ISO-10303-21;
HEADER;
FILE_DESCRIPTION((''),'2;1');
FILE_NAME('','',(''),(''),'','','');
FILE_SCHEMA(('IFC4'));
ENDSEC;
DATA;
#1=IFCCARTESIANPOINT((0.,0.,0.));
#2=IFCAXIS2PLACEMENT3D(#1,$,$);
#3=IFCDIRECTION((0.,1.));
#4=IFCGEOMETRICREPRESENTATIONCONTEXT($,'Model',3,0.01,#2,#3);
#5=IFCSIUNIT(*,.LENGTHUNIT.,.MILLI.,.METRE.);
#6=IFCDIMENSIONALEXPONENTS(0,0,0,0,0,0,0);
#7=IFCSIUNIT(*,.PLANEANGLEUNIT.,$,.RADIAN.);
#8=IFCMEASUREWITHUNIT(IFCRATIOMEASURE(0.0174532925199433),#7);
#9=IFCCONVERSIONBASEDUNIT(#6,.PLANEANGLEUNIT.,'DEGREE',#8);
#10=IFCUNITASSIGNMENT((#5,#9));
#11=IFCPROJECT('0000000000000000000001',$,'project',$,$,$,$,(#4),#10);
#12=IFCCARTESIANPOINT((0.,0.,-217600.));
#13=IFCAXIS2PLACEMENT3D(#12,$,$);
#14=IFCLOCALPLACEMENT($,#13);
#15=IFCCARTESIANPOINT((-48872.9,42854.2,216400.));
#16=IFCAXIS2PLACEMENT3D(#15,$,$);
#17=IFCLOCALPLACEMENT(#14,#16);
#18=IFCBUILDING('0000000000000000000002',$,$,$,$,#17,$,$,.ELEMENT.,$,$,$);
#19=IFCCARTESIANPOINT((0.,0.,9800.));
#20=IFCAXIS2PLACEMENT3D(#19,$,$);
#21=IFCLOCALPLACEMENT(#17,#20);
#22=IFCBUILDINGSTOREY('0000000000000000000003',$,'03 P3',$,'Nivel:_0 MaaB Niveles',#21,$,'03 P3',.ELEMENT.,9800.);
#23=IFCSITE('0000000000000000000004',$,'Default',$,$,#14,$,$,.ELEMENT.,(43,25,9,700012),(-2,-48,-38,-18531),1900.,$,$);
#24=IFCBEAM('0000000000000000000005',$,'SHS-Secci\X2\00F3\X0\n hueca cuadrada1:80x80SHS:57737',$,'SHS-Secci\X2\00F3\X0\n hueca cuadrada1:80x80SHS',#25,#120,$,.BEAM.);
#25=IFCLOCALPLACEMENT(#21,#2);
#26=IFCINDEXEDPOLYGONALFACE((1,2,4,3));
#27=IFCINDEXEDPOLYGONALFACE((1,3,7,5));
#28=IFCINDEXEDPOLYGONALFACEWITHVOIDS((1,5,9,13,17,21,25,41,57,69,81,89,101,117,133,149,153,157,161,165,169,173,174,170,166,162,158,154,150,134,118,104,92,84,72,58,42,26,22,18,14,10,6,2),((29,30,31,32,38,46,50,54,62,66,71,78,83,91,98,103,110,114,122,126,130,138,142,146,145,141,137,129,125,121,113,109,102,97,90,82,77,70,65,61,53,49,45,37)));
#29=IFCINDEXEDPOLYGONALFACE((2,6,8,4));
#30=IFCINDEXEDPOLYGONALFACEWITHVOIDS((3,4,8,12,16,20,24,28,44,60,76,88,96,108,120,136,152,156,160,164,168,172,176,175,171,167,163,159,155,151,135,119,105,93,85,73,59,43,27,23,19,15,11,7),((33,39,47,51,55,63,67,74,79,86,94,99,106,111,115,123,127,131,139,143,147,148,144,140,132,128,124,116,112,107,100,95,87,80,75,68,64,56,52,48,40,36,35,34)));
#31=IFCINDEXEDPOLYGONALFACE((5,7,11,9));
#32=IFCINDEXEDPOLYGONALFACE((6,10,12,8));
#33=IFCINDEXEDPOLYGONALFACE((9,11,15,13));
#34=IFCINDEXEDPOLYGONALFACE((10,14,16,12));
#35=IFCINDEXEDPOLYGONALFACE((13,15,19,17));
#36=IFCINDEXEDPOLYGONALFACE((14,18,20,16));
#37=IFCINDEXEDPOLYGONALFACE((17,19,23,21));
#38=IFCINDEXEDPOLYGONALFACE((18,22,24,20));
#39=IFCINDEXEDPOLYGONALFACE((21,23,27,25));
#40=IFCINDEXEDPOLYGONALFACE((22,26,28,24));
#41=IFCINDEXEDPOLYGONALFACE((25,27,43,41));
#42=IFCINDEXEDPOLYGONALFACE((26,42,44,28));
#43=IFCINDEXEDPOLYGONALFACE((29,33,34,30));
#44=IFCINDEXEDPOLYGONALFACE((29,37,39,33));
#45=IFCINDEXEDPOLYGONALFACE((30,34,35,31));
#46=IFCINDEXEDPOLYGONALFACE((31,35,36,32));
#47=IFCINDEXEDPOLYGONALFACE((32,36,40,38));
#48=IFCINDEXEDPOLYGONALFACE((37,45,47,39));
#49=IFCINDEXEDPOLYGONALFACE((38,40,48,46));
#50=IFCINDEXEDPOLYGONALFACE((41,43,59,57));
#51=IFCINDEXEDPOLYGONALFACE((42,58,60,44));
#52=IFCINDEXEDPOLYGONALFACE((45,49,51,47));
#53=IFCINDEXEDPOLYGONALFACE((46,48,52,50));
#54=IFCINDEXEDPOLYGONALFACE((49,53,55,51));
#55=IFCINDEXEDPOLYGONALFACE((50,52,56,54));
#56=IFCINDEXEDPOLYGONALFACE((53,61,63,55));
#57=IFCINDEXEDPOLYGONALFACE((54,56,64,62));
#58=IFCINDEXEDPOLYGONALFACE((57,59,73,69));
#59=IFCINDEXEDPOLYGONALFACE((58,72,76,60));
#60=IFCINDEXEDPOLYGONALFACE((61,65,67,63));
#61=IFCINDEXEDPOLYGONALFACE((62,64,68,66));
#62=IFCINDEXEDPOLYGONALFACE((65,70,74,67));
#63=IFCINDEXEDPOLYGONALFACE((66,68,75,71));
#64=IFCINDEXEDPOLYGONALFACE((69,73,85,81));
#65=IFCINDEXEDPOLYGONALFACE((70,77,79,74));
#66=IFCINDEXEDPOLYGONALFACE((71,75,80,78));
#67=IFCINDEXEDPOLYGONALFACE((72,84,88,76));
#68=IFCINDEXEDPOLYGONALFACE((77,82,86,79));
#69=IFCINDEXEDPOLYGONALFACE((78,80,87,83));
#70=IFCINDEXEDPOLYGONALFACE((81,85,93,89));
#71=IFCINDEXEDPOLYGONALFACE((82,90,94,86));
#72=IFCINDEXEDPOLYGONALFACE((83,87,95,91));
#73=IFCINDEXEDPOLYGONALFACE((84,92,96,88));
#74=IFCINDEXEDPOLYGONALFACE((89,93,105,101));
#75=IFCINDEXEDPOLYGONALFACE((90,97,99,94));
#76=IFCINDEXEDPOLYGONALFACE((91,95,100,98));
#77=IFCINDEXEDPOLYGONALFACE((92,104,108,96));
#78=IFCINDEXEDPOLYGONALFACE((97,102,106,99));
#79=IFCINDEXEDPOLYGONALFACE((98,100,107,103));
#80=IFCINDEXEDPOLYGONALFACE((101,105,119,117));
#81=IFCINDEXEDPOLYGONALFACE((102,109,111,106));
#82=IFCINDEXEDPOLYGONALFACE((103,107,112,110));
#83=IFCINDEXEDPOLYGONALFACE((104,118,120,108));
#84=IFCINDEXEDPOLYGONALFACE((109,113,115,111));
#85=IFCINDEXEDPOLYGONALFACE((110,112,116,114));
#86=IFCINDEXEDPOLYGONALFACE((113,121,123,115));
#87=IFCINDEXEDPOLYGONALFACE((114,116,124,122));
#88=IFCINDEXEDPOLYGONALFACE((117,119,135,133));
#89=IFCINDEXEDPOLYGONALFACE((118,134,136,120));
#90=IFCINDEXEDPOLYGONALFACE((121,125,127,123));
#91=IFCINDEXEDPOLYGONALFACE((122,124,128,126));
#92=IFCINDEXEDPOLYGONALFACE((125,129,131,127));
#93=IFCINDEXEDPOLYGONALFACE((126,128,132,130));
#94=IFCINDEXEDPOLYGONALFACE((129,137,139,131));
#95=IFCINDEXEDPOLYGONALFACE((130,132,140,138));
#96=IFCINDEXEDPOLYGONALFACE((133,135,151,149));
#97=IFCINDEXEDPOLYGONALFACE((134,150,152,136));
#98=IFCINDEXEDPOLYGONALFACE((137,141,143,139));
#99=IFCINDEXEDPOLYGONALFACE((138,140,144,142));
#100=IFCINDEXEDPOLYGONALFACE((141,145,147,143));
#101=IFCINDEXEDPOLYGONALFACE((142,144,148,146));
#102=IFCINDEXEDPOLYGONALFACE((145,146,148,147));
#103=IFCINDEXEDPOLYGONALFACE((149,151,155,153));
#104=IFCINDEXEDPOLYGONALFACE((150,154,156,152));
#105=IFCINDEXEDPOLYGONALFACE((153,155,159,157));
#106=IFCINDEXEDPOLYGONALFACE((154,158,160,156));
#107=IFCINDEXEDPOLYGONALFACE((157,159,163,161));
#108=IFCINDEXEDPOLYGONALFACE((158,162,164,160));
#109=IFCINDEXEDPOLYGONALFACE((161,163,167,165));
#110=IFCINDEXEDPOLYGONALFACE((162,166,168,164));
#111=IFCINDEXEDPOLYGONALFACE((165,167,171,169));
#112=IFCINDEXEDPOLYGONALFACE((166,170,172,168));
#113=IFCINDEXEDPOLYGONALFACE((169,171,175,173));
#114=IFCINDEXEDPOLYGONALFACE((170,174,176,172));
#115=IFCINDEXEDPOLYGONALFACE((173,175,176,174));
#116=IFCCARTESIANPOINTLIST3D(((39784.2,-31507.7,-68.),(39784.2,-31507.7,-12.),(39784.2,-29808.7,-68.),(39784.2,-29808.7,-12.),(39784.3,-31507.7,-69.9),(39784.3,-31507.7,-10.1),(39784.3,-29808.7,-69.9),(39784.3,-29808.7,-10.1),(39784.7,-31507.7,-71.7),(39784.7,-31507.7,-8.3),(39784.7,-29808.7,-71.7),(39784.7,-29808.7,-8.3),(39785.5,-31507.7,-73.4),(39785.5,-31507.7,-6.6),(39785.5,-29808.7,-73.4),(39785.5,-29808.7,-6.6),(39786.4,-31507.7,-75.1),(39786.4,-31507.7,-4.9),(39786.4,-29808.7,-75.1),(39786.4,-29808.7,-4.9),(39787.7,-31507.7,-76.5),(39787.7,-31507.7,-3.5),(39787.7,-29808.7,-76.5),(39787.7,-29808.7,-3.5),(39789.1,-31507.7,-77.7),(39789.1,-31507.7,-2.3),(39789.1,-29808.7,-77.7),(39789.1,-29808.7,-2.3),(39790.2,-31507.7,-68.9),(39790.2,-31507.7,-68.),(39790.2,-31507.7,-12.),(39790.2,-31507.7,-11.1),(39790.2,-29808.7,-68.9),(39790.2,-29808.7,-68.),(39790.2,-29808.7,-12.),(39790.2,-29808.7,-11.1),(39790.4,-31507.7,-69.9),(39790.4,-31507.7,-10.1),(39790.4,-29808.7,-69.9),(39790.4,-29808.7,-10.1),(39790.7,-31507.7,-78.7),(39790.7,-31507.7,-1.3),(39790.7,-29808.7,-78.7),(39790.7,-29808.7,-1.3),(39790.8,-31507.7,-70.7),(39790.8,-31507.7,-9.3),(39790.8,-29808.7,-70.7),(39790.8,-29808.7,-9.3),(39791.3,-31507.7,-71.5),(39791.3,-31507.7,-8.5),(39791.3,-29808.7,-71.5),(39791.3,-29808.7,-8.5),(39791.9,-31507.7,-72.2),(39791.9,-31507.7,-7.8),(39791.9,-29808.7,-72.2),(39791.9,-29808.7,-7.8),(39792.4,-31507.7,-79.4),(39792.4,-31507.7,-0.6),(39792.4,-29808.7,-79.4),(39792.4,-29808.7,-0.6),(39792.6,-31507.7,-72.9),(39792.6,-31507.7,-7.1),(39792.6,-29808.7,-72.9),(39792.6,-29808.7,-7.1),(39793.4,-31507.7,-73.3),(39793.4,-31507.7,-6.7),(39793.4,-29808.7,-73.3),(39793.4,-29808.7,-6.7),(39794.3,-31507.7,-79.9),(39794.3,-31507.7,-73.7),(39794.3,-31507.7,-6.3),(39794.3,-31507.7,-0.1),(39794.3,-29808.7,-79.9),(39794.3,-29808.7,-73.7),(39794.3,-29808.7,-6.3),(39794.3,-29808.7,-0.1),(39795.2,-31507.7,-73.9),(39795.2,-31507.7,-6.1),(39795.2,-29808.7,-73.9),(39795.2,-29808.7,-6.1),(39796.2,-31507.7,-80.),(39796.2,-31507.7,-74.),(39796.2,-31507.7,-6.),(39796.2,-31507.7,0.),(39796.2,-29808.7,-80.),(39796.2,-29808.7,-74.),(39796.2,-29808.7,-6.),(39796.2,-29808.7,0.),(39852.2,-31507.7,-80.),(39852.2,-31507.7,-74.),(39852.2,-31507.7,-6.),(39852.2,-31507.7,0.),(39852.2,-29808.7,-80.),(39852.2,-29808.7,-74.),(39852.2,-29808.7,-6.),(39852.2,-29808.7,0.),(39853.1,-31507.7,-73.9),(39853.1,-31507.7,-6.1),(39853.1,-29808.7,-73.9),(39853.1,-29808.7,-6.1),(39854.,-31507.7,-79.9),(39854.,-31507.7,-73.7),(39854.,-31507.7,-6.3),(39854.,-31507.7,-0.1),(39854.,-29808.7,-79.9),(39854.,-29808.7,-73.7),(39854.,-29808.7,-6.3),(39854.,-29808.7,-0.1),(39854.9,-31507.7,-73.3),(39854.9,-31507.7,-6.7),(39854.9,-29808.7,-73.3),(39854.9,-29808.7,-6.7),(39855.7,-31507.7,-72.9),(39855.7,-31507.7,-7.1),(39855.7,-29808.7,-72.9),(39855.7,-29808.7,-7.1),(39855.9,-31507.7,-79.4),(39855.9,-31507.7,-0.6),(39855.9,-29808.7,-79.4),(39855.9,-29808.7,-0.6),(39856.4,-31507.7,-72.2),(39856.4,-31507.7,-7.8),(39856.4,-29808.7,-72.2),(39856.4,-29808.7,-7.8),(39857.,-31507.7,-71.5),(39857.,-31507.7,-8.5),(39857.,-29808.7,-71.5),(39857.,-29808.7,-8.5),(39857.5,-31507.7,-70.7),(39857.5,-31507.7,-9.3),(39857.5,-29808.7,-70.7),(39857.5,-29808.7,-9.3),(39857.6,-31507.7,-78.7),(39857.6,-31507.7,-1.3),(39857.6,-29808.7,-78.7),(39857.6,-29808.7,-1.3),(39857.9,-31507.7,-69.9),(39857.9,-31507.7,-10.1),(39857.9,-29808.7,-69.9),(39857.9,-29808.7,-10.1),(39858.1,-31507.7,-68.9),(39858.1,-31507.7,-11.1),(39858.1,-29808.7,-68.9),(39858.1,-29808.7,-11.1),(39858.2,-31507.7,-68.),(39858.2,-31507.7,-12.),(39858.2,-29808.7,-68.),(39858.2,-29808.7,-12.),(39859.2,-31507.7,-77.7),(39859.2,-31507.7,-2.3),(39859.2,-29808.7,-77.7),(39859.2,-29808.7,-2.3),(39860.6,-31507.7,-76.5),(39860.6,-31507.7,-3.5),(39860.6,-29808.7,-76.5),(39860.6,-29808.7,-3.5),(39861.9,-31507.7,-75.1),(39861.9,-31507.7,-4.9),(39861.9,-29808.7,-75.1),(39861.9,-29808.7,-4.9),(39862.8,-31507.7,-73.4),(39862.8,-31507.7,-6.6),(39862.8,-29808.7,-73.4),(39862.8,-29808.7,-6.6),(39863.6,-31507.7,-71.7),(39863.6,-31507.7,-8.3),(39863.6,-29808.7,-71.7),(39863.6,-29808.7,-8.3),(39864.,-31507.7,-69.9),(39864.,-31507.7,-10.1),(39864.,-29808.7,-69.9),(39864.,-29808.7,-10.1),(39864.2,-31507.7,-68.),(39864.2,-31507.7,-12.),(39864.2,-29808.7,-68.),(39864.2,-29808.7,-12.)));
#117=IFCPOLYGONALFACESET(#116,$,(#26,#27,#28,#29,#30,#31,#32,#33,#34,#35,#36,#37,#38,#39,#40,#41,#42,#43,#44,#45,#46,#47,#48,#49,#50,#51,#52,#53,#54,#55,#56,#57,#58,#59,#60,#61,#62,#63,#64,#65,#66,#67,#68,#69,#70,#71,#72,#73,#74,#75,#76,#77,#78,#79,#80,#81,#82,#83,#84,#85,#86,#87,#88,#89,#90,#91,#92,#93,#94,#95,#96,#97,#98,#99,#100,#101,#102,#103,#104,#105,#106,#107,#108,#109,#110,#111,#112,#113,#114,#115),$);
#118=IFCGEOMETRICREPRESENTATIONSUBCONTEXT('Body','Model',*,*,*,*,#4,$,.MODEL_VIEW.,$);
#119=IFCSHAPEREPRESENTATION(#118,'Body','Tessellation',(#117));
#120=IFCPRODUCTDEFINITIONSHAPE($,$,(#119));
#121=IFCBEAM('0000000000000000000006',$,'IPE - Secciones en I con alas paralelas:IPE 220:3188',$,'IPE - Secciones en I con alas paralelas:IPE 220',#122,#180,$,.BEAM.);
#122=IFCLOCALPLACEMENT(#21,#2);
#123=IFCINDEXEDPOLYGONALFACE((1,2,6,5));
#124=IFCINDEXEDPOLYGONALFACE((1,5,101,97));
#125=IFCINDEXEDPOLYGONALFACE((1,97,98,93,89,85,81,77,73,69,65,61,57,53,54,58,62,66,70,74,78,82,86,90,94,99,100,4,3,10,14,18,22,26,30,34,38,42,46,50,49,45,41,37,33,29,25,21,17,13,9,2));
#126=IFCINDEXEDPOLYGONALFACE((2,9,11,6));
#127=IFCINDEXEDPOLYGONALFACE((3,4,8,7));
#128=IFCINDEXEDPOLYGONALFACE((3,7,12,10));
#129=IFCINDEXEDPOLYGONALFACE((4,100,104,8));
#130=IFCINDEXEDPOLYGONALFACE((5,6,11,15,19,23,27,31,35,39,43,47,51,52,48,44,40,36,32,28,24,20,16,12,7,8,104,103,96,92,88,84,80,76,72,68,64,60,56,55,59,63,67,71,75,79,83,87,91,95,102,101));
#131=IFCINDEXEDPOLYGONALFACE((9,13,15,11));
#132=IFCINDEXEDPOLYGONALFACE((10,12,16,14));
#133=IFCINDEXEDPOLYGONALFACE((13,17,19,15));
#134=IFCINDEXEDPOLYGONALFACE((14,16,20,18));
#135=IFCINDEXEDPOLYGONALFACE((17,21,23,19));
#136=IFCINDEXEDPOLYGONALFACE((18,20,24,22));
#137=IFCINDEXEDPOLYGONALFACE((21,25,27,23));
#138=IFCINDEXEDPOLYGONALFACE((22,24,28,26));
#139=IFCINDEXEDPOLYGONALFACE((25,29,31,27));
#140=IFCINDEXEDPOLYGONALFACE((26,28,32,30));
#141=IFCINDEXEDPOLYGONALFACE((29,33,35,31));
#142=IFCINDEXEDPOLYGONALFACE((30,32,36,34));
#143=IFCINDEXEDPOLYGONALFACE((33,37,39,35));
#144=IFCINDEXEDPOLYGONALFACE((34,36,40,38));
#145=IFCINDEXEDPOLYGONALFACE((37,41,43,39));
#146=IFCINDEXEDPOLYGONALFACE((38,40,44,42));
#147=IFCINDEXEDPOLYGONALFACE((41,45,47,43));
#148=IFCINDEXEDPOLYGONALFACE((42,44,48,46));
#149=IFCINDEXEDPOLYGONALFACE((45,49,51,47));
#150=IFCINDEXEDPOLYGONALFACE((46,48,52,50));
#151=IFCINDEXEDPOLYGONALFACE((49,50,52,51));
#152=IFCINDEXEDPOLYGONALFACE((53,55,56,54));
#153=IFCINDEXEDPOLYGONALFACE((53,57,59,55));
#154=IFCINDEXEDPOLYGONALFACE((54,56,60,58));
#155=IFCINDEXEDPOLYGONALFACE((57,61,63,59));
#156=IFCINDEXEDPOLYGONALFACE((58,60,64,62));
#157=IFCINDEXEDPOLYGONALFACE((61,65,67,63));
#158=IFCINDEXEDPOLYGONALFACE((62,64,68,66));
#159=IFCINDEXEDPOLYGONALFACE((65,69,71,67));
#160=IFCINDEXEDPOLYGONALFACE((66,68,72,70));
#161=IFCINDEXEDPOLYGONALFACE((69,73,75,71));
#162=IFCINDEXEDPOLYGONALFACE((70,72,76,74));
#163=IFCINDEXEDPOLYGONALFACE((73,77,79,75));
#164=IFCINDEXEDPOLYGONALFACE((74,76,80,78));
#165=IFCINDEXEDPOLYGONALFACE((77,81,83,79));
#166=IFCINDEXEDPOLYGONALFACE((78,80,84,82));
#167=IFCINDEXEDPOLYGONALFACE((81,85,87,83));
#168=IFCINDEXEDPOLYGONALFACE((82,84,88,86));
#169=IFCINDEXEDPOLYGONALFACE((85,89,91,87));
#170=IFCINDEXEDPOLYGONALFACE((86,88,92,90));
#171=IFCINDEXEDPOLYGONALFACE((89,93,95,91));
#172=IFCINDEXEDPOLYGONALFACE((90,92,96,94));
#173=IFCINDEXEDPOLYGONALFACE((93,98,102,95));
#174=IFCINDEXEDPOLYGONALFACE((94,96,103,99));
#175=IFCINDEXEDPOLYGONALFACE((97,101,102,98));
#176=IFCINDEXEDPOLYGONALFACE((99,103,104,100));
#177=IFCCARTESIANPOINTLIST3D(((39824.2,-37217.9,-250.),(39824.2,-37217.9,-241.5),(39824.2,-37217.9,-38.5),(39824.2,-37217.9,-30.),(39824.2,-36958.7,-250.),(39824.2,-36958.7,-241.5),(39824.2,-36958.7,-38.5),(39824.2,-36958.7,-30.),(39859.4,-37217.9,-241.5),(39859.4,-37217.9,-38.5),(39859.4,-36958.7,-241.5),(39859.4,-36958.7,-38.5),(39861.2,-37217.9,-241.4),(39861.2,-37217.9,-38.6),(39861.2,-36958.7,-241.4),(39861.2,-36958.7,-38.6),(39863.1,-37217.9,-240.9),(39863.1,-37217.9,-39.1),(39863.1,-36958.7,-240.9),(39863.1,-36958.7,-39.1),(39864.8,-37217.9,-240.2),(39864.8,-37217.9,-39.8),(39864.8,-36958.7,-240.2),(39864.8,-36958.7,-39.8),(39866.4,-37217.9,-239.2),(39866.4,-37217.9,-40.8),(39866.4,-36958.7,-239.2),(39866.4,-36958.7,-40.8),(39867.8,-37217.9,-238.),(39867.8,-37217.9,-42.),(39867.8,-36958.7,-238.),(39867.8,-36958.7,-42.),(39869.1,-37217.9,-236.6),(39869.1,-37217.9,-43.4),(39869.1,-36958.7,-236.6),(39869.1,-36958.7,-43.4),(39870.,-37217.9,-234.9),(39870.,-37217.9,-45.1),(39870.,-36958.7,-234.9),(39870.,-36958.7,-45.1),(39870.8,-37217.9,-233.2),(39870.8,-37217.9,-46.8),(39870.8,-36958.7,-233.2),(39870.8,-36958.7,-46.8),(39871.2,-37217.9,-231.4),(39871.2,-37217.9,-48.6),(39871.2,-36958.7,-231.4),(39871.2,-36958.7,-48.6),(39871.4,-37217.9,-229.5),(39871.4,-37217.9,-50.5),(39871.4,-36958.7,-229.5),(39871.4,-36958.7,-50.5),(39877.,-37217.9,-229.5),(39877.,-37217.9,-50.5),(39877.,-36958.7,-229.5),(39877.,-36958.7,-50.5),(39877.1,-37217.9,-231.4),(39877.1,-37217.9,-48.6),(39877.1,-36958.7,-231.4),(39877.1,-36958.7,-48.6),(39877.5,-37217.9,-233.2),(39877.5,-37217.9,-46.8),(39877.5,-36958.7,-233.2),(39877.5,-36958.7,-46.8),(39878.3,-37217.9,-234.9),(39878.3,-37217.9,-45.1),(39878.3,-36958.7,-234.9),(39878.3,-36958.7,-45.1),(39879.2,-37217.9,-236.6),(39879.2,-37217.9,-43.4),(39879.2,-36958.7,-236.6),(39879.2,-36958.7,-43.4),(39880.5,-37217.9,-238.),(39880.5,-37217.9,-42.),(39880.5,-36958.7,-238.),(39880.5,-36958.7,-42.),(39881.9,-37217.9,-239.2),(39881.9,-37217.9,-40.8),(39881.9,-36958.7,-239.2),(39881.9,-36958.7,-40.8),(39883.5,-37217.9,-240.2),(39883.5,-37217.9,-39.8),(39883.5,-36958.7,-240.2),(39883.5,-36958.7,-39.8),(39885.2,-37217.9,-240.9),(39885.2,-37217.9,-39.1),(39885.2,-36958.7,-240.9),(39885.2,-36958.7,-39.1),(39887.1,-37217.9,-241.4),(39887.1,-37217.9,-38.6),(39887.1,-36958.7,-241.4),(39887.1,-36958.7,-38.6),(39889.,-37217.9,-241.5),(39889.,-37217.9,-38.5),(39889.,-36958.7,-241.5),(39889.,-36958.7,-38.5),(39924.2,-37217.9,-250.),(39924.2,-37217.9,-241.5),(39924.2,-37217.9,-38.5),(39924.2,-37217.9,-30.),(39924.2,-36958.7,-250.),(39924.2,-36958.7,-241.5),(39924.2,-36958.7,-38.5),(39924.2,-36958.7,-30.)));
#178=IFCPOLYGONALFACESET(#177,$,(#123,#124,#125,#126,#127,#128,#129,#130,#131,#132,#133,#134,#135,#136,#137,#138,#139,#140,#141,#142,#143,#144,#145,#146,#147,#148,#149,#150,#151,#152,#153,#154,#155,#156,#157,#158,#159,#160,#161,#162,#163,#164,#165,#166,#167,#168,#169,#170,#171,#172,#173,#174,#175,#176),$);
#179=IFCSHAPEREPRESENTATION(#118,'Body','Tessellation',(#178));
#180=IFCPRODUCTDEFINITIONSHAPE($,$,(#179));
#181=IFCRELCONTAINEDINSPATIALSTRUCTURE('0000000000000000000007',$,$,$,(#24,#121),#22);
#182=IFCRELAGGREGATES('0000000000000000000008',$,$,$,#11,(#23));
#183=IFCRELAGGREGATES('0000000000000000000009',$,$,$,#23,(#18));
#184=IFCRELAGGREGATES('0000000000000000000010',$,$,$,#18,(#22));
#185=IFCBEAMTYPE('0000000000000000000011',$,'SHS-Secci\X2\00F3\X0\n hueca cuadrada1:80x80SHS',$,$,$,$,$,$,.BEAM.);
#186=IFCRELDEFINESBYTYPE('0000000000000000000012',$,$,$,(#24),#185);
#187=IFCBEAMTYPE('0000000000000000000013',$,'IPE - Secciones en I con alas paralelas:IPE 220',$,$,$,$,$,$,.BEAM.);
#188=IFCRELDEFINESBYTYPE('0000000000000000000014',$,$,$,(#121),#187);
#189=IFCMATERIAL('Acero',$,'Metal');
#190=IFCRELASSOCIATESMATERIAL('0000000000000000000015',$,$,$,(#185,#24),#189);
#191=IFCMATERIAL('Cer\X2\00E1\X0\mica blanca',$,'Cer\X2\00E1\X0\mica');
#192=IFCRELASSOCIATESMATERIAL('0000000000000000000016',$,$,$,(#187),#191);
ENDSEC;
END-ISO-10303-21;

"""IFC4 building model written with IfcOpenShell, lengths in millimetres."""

from ifc_helpers import new_model, entity, si_unit, converted_unit, direction, frame, origin, place, context, subcontext, project, spatial, indexed_curve, outline, extrude, source, transform, mapped, material, type_object, type_shapes, element, save


model = new_model("IFC4")

# Units and contexts
model_context = context("Model", 3, precision=0.01, world=origin(), true_north=direction((0.0, 1.0)))
body_context = subcontext(model_context, "Body", "Model", "MODEL_VIEW")
ifc_project = project(units=[si_unit("LENGTHUNIT", "METRE", prefix="MILLI"), converted_unit("PLANEANGLEUNIT", "DEGREE", entity("IfcRatioMeasure", 0.0174532925199433), si_unit("PLANEANGLEUNIT", "RADIAN"), dimensions=[0, 0, 0, 0, 0, 0, 0])], contexts=[model_context])

# Site, building, storey
site_placement = place(None, frame((0.0, 0.0, -217600.0)))
site = spatial("IfcSite", under=ifc_project, at=site_placement, Name="Default", CompositionType="ELEMENT", RefLatitude=(43, 25, 9, 700012), RefLongitude=(-2, -48, -38, -18531), RefElevation=1900.0)
building_placement = place(site_placement, frame((-48872.9, 42854.2, 216400.0)))
building = spatial("IfcBuilding", under=site, at=building_placement, CompositionType="ELEMENT")
storey_placement = place(building_placement, frame((0.0, 0.0, 9800.0)))
storey = spatial("IfcBuildingStorey", under=building, at=storey_placement, Name="03 P3", ObjectType="Nivel:_0 MaaB Niveles", LongName="03 P3", CompositionType="ELEMENT", Elevation=9800.0)

# Shared definitions
ifc_material_1 = material(Name="Acero", Category="Metal")

# Beams
beam_type_1 = type_object("IfcBeamType", Name="SHS-Sección hueca cuadrada1:80x80SHS", PredefinedType="BEAM", material=ifc_material_1)
shared_shape_1 = source(origin(), body_context, "Body", "SweptSolid", [
    extrude(outline(indexed_curve([(-40.0, -28.0), (-39.9, -29.9), (-39.4, -31.7), (-38.7, -33.4), (-37.7, -35.1), (-36.5, -36.5), (-35.1, -37.7), (-33.4, -38.7), (-31.7, -39.4), (-29.9, -39.9), (-28.0, -40.0), (28.0, -40.0), (29.9, -39.9), (31.7, -39.4), (33.4, -38.7), (35.1, -37.7), (36.5, -36.5), (37.7, -35.1), (38.7, -33.4), (39.4, -31.7), (39.9, -29.9), (40.0, -28.0), (40.0, 28.0), (39.9, 29.9), (39.4, 31.7), (38.7, 33.4), (37.7, 35.1), (36.5, 36.5), (35.1, 37.7), (33.4, 38.7), (31.7, 39.4), (29.9, 39.9), (28.0, 40.0), (-28.0, 40.0), (-29.9, 39.9), (-31.7, 39.4), (-33.4, 38.7), (-35.1, 37.7), (-36.5, 36.5), (-37.7, 35.1), (-38.7, 33.4), (-39.4, 31.7), (-39.9, 29.9), (-40.0, 28.0), (-40.0, -28.0)], self_intersect=False), holes=[indexed_curve([(28.0, -34.0), (-28.0, -34.0), (-28.9, -33.9), (-29.9, -33.7), (-30.7, -33.3), (-31.5, -32.9), (-32.2, -32.2), (-32.9, -31.5), (-33.3, -30.7), (-33.7, -29.9), (-33.9, -28.9), (-34.0, -28.0), (-34.0, 28.0), (-33.9, 28.9), (-33.7, 29.9), (-33.3, 30.7), (-32.9, 31.5), (-32.2, 32.2), (-31.5, 32.9), (-30.7, 33.3), (-29.9, 33.7), (-28.9, 33.9), (-28.0, 34.0), (28.0, 34.0), (28.9, 33.9), (29.9, 33.7), (30.7, 33.3), (31.5, 32.9), (32.2, 32.2), (32.9, 31.5), (33.3, 30.7), (33.7, 29.9), (33.9, 28.9), (34.0, 28.0), (34.0, -28.0), (33.9, -28.9), (33.7, -29.9), (33.3, -30.7), (32.9, -31.5), (32.2, -32.2), (31.5, -32.9), (30.7, -33.3), (29.9, -33.7), (28.9, -33.9), (28.0, -34.0)], self_intersect=False)]), frame((-827.5, 0.0, 0.0), z_axis=(1.0, 0.0, 0.0), x_axis=(0.0, -1.0, 0.0)), (0.0, 0.0, 1.0), 1699.0),
])
type_shapes(beam_type_1, [shared_shape_1])
beam_1_placement = place(storey_placement, frame((39824.2, -30636.2, -40.0), z_axis=(0.0, 0.0, 1.0), x_axis=(0.0, -1.0, 0.0)))
element("IfcBeam", 1, at=beam_1_placement, inside=storey, type_object=beam_type_1, material=ifc_material_1, Name="SHS-Sección hueca cuadrada1:80x80SHS:57737", ObjectType="SHS-Sección hueca cuadrada1:80x80SHS", PredefinedType="BEAM", context=body_context, shape_type="MappedRepresentation", body=[
    mapped(shared_shape_1, transform((0.0, 0.0, 0.0), scale=1.0)),
])
ifc_material_2 = material(Name="Cerámica blanca", Category="Cerámica")
beam_type_2 = type_object("IfcBeamType", Name="IPE - Secciones en I con alas paralelas:IPE 220", PredefinedType="BEAM", material=ifc_material_2)
shared_shape_2 = source(origin(), body_context, "Body", "SweptSolid", [
    extrude(outline(indexed_curve([(-110.0, -50.0), (-101.5, -50.0), (-101.5, -14.8), (-101.4, -12.9), (-100.9, -11.1), (-100.2, -9.4), (-99.2, -7.7), (-98.0, -6.3), (-96.6, -5.1), (-94.9, -4.1), (-93.2, -3.4), (-91.4, -2.9), (-89.5, -2.8), (89.5, -2.8), (91.4, -2.9), (93.2, -3.4), (94.9, -4.1), (96.6, -5.1), (98.0, -6.3), (99.2, -7.7), (100.2, -9.4), (100.9, -11.1), (101.4, -12.9), (101.5, -14.8), (101.5, -50.0), (110.0, -50.0), (110.0, 50.0), (101.5, 50.0), (101.5, 14.8), (101.4, 12.9), (100.9, 11.1), (100.2, 9.4), (99.2, 7.7), (98.0, 6.3), (96.6, 5.1), (94.9, 4.1), (93.2, 3.4), (91.4, 2.9), (89.5, 2.8), (-89.5, 2.8), (-91.4, 2.9), (-93.2, 3.4), (-94.9, 4.1), (-96.6, 5.1), (-98.0, 6.3), (-99.2, 7.7), (-100.2, 9.4), (-100.9, 11.1), (-101.4, 12.9), (-101.5, 14.8), (-101.5, 50.0), (-110.0, 50.0), (-110.0, -50.0)], self_intersect=False)), frame((-41.7, 0.0, 0.0), z_axis=(1.0, 0.0, 0.0), x_axis=(0.0, 0.0, -1.0)), (0.0, 0.0, 1.0), 259.2),
])
type_shapes(beam_type_2, [shared_shape_2])
beam_2_placement = place(storey_placement, frame((39874.2, -37176.2, -140.0), z_axis=(0.0, 0.0, 1.0), x_axis=(0.0, 1.0, 0.0)))
element("IfcBeam", 2, at=beam_2_placement, inside=storey, type_object=beam_type_2, Name="IPE - Secciones en I con alas paralelas:IPE 220:3188", ObjectType="IPE - Secciones en I con alas paralelas:IPE 220", PredefinedType="BEAM", context=body_context, shape_type="MappedRepresentation", body=[
    mapped(shared_shape_2, transform((0.0, 0.0, 0.0), scale=1.0)),
])

save(model, "model.ifc")
